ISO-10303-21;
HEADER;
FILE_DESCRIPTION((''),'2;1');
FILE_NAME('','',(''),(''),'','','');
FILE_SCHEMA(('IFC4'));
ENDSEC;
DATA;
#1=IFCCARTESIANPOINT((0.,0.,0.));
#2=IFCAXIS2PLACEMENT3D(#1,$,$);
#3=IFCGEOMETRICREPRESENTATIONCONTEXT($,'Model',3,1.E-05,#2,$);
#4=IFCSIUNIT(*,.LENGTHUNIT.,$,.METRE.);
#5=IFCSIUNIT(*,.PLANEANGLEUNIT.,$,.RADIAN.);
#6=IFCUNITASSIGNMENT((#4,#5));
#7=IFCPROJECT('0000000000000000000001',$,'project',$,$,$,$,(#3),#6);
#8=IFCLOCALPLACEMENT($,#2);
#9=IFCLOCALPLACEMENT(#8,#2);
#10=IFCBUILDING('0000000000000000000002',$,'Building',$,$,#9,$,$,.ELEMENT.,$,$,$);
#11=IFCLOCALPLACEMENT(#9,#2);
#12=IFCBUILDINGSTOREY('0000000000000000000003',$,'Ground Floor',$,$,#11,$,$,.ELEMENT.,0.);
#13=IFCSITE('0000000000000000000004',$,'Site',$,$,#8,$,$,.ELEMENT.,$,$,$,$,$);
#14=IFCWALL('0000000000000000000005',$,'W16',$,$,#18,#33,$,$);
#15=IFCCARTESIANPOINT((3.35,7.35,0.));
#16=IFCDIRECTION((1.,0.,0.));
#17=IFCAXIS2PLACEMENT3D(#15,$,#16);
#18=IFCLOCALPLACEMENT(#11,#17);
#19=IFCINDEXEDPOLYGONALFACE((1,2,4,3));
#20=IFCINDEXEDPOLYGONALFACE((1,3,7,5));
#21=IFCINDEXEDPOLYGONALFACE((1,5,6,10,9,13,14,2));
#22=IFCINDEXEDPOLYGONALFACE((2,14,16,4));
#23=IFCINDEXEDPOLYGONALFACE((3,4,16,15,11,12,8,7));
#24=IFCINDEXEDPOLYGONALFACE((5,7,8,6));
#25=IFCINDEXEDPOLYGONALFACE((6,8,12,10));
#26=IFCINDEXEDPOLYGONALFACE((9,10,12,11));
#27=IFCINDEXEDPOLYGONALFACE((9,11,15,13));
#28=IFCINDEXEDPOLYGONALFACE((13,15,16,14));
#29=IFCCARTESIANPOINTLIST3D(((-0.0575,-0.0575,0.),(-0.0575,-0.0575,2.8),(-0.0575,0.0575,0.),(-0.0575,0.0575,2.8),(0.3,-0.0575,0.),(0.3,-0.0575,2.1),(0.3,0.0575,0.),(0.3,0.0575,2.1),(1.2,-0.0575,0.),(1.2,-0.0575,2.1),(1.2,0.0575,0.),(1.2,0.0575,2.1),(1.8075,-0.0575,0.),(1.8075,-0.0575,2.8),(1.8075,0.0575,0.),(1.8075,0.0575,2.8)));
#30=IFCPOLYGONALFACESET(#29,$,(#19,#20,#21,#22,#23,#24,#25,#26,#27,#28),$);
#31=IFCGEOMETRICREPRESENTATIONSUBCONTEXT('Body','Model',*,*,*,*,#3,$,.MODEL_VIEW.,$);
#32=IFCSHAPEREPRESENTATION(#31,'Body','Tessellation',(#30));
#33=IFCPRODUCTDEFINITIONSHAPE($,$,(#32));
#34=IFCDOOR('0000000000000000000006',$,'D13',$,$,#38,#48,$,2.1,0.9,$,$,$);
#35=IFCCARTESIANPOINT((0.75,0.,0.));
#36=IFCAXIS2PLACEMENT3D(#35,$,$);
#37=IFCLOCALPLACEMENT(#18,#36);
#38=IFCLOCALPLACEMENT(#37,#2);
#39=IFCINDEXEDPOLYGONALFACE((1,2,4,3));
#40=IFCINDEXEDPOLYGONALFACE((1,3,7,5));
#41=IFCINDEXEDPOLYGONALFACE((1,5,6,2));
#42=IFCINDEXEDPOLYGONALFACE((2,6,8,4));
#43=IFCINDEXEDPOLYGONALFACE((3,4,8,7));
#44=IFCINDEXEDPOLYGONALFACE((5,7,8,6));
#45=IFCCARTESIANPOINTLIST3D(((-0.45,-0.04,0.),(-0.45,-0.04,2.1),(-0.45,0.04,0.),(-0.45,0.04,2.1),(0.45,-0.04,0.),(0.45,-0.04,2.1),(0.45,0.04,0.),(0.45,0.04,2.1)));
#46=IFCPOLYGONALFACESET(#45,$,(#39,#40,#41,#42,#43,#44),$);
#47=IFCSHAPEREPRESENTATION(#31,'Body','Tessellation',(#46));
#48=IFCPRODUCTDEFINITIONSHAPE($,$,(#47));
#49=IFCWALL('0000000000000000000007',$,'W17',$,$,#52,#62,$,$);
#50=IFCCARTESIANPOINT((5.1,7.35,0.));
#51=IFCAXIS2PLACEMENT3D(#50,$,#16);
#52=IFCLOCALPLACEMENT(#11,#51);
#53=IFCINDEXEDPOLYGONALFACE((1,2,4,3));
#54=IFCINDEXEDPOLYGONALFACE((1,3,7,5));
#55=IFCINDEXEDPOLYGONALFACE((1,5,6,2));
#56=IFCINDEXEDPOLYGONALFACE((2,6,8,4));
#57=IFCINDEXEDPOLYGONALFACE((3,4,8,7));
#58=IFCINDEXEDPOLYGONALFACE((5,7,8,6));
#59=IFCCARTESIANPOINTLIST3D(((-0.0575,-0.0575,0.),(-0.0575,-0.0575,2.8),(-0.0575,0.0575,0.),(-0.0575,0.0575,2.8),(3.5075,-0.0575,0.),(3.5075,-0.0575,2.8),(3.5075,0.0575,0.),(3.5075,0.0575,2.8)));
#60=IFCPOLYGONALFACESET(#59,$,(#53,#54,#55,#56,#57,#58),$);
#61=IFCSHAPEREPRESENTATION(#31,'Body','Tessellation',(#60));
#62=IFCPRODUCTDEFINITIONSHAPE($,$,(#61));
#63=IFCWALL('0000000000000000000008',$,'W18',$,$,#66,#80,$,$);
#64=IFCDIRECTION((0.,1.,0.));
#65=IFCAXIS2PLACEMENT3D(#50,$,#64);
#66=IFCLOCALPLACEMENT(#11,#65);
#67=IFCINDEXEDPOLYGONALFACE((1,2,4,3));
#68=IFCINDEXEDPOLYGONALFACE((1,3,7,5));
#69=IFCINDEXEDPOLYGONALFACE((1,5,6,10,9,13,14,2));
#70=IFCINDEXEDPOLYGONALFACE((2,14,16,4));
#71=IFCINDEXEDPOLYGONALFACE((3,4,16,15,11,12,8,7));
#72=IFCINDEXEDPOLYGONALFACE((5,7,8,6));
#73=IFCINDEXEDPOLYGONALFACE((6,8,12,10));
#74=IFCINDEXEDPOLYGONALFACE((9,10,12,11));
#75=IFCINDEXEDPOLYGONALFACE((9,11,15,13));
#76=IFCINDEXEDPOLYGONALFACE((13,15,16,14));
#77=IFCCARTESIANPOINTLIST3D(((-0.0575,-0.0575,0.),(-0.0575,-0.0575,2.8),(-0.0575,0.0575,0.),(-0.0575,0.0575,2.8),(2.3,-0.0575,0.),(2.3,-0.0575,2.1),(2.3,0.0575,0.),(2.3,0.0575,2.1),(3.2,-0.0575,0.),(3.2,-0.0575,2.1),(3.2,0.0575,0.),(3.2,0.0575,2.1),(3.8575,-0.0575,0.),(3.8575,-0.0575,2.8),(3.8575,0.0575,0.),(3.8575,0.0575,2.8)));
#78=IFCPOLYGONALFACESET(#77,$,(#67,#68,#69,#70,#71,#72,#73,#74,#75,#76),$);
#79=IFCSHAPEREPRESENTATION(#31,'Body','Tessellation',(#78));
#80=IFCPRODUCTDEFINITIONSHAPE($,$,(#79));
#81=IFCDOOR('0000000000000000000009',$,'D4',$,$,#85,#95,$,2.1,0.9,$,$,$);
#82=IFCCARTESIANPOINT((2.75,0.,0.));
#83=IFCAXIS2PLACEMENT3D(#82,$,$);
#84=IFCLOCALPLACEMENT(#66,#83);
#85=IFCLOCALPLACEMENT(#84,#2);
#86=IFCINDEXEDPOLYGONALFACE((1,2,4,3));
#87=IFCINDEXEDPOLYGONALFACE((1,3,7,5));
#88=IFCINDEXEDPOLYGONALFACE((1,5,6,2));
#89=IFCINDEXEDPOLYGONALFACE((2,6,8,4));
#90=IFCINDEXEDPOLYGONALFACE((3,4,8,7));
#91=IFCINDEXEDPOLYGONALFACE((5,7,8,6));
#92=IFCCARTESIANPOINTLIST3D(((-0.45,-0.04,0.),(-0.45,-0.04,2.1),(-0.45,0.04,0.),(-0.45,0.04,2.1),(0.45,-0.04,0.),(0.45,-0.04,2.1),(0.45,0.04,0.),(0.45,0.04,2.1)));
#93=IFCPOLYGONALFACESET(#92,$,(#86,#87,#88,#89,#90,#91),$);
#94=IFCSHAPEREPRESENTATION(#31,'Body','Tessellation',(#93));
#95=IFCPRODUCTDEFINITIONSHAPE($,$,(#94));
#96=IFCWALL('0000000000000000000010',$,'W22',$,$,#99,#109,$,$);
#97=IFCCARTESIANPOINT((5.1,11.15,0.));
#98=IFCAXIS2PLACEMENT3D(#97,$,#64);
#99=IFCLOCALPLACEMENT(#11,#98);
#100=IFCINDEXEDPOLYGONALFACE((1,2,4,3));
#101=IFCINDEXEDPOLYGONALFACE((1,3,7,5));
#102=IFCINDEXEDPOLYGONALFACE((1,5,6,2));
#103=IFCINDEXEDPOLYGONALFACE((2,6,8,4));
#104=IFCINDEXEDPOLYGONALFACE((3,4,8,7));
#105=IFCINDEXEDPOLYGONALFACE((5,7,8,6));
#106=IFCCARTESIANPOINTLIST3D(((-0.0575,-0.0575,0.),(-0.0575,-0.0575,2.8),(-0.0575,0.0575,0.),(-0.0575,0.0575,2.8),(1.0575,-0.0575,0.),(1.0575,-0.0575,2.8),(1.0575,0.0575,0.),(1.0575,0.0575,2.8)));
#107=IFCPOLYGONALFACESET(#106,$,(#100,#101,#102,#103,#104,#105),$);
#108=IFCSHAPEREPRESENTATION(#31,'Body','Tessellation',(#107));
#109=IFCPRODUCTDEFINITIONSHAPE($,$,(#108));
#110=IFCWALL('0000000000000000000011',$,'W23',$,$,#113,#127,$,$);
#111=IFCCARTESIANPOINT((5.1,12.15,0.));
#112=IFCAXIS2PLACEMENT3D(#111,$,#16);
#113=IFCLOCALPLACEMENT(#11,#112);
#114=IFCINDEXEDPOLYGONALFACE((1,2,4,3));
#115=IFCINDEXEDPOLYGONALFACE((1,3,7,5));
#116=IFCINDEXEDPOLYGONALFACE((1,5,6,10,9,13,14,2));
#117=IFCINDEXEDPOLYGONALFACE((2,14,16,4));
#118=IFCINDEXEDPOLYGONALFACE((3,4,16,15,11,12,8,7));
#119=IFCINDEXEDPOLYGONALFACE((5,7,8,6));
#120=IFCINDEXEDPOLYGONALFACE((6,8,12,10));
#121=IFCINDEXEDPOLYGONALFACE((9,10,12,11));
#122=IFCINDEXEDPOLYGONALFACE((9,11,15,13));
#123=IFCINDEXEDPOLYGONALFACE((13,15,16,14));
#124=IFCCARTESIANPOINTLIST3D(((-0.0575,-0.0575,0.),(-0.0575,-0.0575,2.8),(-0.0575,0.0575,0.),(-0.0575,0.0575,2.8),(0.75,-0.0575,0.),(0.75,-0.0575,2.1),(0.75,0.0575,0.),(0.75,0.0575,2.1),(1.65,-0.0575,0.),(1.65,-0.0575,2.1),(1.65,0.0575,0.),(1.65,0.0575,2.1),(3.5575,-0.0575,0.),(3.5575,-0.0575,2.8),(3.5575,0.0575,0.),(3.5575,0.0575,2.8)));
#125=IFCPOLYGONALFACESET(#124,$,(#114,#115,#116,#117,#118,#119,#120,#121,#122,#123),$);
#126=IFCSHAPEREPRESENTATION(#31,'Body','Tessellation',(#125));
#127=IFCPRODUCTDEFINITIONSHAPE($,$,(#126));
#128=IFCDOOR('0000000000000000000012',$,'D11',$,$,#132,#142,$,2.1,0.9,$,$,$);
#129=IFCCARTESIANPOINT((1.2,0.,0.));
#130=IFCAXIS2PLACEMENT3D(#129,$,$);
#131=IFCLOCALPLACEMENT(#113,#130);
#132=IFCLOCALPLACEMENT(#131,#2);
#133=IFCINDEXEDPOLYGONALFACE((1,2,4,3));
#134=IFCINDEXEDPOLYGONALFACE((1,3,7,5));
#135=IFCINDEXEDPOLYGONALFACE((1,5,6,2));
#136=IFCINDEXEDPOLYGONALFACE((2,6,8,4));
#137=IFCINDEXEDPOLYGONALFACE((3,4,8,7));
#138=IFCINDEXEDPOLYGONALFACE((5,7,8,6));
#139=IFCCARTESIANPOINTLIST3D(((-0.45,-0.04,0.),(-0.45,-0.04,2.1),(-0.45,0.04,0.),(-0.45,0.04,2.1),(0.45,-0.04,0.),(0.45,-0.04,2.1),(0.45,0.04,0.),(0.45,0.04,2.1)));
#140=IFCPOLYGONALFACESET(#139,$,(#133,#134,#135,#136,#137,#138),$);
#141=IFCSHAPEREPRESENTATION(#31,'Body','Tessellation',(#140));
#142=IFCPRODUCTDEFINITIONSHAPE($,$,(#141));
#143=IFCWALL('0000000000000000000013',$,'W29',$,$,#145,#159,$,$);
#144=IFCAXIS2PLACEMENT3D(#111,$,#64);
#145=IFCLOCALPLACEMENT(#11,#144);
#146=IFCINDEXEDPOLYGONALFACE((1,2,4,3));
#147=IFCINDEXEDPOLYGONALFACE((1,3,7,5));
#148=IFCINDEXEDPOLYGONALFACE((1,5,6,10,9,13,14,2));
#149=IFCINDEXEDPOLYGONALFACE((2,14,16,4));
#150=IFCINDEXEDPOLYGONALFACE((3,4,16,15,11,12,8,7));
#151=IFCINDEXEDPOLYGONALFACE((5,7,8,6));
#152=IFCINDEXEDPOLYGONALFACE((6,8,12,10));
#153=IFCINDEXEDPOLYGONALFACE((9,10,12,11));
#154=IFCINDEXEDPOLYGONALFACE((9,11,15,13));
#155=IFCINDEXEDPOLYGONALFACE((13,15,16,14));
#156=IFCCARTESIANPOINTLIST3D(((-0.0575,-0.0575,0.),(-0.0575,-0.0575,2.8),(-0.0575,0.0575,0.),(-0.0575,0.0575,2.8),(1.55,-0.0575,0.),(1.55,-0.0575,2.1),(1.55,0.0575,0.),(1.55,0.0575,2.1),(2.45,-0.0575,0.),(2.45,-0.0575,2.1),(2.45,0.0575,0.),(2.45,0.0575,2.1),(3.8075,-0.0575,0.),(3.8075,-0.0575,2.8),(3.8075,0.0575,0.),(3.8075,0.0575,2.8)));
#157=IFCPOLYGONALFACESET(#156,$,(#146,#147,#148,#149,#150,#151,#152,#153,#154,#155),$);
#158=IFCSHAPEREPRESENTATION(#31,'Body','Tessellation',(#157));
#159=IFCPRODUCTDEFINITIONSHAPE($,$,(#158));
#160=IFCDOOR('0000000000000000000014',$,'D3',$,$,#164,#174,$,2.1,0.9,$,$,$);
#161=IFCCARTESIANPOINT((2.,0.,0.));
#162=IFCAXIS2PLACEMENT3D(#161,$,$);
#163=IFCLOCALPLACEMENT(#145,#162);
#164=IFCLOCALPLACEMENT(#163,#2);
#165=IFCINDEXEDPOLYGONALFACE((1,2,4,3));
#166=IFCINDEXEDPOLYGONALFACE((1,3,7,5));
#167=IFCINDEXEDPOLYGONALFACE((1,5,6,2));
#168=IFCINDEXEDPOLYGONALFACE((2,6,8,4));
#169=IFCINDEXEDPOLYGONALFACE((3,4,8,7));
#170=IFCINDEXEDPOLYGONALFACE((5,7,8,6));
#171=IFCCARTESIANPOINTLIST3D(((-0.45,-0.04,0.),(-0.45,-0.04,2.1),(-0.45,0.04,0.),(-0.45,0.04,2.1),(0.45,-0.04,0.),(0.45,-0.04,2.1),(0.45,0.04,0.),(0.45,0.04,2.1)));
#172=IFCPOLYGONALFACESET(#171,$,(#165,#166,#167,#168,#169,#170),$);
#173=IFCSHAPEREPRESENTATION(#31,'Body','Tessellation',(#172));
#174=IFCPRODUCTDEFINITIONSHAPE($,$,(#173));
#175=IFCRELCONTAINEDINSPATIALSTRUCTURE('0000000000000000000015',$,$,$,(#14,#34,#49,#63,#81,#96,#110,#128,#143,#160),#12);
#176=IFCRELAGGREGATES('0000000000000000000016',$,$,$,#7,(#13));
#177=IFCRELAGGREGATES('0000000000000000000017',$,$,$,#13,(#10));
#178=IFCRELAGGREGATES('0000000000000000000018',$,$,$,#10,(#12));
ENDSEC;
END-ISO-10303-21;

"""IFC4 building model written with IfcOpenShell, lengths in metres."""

from ifc_helpers import new_model, si_unit, frame, frame_2d, origin, origin_2d, place, context, subcontext, project, spatial, rectangle, extrude, element, fill, save


model = new_model("IFC4")

# Units and contexts
model_context = context("Model", 3, precision=1e-05, world=origin())
body_context = subcontext(model_context, "Body", "Model", "MODEL_VIEW")
ifc_project = project(units=[si_unit("LENGTHUNIT", "METRE"), si_unit("PLANEANGLEUNIT", "RADIAN")], contexts=[model_context])

# Site, building, storey
site_placement = place(None, origin())
site = spatial("IfcSite", under=ifc_project, at=site_placement, Name="Site", CompositionType="ELEMENT")
building_placement = place(site_placement, origin())
building = spatial("IfcBuilding", under=site, at=building_placement, Name="Building", CompositionType="ELEMENT")
storey_placement = place(building_placement, origin())
storey = spatial("IfcBuildingStorey", under=building, at=storey_placement, Name="Ground Floor", CompositionType="ELEMENT", Elevation=0.0)

# Wall, opening, door
wall_1_placement = place(storey_placement, frame((3.35, 7.35, 0.0), x_axis=(1.0, 0.0, 0.0)))
wall_1 = element("IfcWall", 1, at=wall_1_placement, inside=storey, Name="W16", context=body_context, shape_type="SweptSolid", body=[
    extrude(rectangle(XDim=1.865, YDim=0.115, at=frame_2d((0.875, 0.0))), origin(), (0.0, 0.0, 1.0), 2.8),
])
opening_1_placement = place(wall_1_placement, frame((0.75, 0.0, 0.0)))
opening_1 = element("IfcOpeningElement", 2, at=opening_1_placement, cuts=wall_1, context=body_context, shape_type="SweptSolid", body=[
    extrude(rectangle(XDim=0.9, YDim=0.215, at=origin_2d()), origin(), (0.0, 0.0, 1.0), 2.1),
])
door_1_placement = place(opening_1_placement, origin())
door_1 = element("IfcDoor", 3, at=door_1_placement, inside=storey, Name="D13", OverallHeight=2.1, OverallWidth=0.9, context=body_context, shape_type="SweptSolid", body=[
    extrude(rectangle(XDim=0.9, YDim=0.08, at=origin_2d()), origin(), (0.0, 0.0, 1.0), 2.1),
])
fill(opening_1, door_1)

# Wall
wall_2_placement = place(storey_placement, frame((5.1, 7.35, 0.0), x_axis=(1.0, 0.0, 0.0)))
element("IfcWall", 4, at=wall_2_placement, inside=storey, Name="W17", context=body_context, shape_type="SweptSolid", body=[
    extrude(rectangle(XDim=3.565, YDim=0.115, at=frame_2d((1.725, 0.0))), origin(), (0.0, 0.0, 1.0), 2.8),
])

# Wall, opening, door
wall_3_placement = place(storey_placement, frame((5.1, 7.35, 0.0), x_axis=(0.0, 1.0, 0.0)))
wall_3 = element("IfcWall", 5, at=wall_3_placement, inside=storey, Name="W18", context=body_context, shape_type="SweptSolid", body=[
    extrude(rectangle(XDim=3.915, YDim=0.115, at=frame_2d((1.9, 0.0))), origin(), (0.0, 0.0, 1.0), 2.8),
])
opening_2_placement = place(wall_3_placement, frame((2.75, 0.0, 0.0)))
opening_2 = element("IfcOpeningElement", 6, at=opening_2_placement, cuts=wall_3, context=body_context, shape_type="SweptSolid", body=[
    extrude(rectangle(XDim=0.9, YDim=0.215, at=origin_2d()), origin(), (0.0, 0.0, 1.0), 2.1),
])
door_2_placement = place(opening_2_placement, origin())
door_2 = element("IfcDoor", 7, at=door_2_placement, inside=storey, Name="D4", OverallHeight=2.1, OverallWidth=0.9, context=body_context, shape_type="SweptSolid", body=[
    extrude(rectangle(XDim=0.9, YDim=0.08, at=origin_2d()), origin(), (0.0, 0.0, 1.0), 2.1),
])
fill(opening_2, door_2)

# Wall
wall_4_placement = place(storey_placement, frame((5.1, 11.15, 0.0), x_axis=(0.0, 1.0, 0.0)))
element("IfcWall", 8, at=wall_4_placement, inside=storey, Name="W22", context=body_context, shape_type="SweptSolid", body=[
    extrude(rectangle(XDim=1.115, YDim=0.115, at=frame_2d((0.5, 0.0))), origin(), (0.0, 0.0, 1.0), 2.8),
])

# Walls, openings, doors
wall_5_placement = place(storey_placement, frame((5.1, 12.15, 0.0), x_axis=(1.0, 0.0, 0.0)))
wall_5 = element("IfcWall", 9, at=wall_5_placement, inside=storey, Name="W23", context=body_context, shape_type="SweptSolid", body=[
    extrude(rectangle(XDim=3.615, YDim=0.115, at=frame_2d((1.75, 0.0))), origin(), (0.0, 0.0, 1.0), 2.8),
])
opening_3_placement = place(wall_5_placement, frame((1.2, 0.0, 0.0)))
opening_3 = element("IfcOpeningElement", 10, at=opening_3_placement, cuts=wall_5, context=body_context, shape_type="SweptSolid", body=[
    extrude(rectangle(XDim=0.9, YDim=0.215, at=origin_2d()), origin(), (0.0, 0.0, 1.0), 2.1),
])
door_3_placement = place(opening_3_placement, origin())
door_3 = element("IfcDoor", 11, at=door_3_placement, inside=storey, Name="D11", OverallHeight=2.1, OverallWidth=0.9, context=body_context, shape_type="SweptSolid", body=[
    extrude(rectangle(XDim=0.9, YDim=0.08, at=origin_2d()), origin(), (0.0, 0.0, 1.0), 2.1),
])
fill(opening_3, door_3)
wall_6_placement = place(storey_placement, frame((5.1, 12.15, 0.0), x_axis=(0.0, 1.0, 0.0)))
wall_6 = element("IfcWall", 12, at=wall_6_placement, inside=storey, Name="W29", context=body_context, shape_type="SweptSolid", body=[
    extrude(rectangle(XDim=3.865, YDim=0.115, at=frame_2d((1.875, 0.0))), origin(), (0.0, 0.0, 1.0), 2.8),
])
opening_4_placement = place(wall_6_placement, frame((2.0, 0.0, 0.0)))
opening_4 = element("IfcOpeningElement", 13, at=opening_4_placement, cuts=wall_6, context=body_context, shape_type="SweptSolid", body=[
    extrude(rectangle(XDim=0.9, YDim=0.215, at=origin_2d()), origin(), (0.0, 0.0, 1.0), 2.1),
])
door_4_placement = place(opening_4_placement, origin())
door_4 = element("IfcDoor", 14, at=door_4_placement, inside=storey, Name="D3", OverallHeight=2.1, OverallWidth=0.9, context=body_context, shape_type="SweptSolid", body=[
    extrude(rectangle(XDim=0.9, YDim=0.08, at=origin_2d()), origin(), (0.0, 0.0, 1.0), 2.1),
])
fill(opening_4, door_4)

save(model, "model.ifc")
